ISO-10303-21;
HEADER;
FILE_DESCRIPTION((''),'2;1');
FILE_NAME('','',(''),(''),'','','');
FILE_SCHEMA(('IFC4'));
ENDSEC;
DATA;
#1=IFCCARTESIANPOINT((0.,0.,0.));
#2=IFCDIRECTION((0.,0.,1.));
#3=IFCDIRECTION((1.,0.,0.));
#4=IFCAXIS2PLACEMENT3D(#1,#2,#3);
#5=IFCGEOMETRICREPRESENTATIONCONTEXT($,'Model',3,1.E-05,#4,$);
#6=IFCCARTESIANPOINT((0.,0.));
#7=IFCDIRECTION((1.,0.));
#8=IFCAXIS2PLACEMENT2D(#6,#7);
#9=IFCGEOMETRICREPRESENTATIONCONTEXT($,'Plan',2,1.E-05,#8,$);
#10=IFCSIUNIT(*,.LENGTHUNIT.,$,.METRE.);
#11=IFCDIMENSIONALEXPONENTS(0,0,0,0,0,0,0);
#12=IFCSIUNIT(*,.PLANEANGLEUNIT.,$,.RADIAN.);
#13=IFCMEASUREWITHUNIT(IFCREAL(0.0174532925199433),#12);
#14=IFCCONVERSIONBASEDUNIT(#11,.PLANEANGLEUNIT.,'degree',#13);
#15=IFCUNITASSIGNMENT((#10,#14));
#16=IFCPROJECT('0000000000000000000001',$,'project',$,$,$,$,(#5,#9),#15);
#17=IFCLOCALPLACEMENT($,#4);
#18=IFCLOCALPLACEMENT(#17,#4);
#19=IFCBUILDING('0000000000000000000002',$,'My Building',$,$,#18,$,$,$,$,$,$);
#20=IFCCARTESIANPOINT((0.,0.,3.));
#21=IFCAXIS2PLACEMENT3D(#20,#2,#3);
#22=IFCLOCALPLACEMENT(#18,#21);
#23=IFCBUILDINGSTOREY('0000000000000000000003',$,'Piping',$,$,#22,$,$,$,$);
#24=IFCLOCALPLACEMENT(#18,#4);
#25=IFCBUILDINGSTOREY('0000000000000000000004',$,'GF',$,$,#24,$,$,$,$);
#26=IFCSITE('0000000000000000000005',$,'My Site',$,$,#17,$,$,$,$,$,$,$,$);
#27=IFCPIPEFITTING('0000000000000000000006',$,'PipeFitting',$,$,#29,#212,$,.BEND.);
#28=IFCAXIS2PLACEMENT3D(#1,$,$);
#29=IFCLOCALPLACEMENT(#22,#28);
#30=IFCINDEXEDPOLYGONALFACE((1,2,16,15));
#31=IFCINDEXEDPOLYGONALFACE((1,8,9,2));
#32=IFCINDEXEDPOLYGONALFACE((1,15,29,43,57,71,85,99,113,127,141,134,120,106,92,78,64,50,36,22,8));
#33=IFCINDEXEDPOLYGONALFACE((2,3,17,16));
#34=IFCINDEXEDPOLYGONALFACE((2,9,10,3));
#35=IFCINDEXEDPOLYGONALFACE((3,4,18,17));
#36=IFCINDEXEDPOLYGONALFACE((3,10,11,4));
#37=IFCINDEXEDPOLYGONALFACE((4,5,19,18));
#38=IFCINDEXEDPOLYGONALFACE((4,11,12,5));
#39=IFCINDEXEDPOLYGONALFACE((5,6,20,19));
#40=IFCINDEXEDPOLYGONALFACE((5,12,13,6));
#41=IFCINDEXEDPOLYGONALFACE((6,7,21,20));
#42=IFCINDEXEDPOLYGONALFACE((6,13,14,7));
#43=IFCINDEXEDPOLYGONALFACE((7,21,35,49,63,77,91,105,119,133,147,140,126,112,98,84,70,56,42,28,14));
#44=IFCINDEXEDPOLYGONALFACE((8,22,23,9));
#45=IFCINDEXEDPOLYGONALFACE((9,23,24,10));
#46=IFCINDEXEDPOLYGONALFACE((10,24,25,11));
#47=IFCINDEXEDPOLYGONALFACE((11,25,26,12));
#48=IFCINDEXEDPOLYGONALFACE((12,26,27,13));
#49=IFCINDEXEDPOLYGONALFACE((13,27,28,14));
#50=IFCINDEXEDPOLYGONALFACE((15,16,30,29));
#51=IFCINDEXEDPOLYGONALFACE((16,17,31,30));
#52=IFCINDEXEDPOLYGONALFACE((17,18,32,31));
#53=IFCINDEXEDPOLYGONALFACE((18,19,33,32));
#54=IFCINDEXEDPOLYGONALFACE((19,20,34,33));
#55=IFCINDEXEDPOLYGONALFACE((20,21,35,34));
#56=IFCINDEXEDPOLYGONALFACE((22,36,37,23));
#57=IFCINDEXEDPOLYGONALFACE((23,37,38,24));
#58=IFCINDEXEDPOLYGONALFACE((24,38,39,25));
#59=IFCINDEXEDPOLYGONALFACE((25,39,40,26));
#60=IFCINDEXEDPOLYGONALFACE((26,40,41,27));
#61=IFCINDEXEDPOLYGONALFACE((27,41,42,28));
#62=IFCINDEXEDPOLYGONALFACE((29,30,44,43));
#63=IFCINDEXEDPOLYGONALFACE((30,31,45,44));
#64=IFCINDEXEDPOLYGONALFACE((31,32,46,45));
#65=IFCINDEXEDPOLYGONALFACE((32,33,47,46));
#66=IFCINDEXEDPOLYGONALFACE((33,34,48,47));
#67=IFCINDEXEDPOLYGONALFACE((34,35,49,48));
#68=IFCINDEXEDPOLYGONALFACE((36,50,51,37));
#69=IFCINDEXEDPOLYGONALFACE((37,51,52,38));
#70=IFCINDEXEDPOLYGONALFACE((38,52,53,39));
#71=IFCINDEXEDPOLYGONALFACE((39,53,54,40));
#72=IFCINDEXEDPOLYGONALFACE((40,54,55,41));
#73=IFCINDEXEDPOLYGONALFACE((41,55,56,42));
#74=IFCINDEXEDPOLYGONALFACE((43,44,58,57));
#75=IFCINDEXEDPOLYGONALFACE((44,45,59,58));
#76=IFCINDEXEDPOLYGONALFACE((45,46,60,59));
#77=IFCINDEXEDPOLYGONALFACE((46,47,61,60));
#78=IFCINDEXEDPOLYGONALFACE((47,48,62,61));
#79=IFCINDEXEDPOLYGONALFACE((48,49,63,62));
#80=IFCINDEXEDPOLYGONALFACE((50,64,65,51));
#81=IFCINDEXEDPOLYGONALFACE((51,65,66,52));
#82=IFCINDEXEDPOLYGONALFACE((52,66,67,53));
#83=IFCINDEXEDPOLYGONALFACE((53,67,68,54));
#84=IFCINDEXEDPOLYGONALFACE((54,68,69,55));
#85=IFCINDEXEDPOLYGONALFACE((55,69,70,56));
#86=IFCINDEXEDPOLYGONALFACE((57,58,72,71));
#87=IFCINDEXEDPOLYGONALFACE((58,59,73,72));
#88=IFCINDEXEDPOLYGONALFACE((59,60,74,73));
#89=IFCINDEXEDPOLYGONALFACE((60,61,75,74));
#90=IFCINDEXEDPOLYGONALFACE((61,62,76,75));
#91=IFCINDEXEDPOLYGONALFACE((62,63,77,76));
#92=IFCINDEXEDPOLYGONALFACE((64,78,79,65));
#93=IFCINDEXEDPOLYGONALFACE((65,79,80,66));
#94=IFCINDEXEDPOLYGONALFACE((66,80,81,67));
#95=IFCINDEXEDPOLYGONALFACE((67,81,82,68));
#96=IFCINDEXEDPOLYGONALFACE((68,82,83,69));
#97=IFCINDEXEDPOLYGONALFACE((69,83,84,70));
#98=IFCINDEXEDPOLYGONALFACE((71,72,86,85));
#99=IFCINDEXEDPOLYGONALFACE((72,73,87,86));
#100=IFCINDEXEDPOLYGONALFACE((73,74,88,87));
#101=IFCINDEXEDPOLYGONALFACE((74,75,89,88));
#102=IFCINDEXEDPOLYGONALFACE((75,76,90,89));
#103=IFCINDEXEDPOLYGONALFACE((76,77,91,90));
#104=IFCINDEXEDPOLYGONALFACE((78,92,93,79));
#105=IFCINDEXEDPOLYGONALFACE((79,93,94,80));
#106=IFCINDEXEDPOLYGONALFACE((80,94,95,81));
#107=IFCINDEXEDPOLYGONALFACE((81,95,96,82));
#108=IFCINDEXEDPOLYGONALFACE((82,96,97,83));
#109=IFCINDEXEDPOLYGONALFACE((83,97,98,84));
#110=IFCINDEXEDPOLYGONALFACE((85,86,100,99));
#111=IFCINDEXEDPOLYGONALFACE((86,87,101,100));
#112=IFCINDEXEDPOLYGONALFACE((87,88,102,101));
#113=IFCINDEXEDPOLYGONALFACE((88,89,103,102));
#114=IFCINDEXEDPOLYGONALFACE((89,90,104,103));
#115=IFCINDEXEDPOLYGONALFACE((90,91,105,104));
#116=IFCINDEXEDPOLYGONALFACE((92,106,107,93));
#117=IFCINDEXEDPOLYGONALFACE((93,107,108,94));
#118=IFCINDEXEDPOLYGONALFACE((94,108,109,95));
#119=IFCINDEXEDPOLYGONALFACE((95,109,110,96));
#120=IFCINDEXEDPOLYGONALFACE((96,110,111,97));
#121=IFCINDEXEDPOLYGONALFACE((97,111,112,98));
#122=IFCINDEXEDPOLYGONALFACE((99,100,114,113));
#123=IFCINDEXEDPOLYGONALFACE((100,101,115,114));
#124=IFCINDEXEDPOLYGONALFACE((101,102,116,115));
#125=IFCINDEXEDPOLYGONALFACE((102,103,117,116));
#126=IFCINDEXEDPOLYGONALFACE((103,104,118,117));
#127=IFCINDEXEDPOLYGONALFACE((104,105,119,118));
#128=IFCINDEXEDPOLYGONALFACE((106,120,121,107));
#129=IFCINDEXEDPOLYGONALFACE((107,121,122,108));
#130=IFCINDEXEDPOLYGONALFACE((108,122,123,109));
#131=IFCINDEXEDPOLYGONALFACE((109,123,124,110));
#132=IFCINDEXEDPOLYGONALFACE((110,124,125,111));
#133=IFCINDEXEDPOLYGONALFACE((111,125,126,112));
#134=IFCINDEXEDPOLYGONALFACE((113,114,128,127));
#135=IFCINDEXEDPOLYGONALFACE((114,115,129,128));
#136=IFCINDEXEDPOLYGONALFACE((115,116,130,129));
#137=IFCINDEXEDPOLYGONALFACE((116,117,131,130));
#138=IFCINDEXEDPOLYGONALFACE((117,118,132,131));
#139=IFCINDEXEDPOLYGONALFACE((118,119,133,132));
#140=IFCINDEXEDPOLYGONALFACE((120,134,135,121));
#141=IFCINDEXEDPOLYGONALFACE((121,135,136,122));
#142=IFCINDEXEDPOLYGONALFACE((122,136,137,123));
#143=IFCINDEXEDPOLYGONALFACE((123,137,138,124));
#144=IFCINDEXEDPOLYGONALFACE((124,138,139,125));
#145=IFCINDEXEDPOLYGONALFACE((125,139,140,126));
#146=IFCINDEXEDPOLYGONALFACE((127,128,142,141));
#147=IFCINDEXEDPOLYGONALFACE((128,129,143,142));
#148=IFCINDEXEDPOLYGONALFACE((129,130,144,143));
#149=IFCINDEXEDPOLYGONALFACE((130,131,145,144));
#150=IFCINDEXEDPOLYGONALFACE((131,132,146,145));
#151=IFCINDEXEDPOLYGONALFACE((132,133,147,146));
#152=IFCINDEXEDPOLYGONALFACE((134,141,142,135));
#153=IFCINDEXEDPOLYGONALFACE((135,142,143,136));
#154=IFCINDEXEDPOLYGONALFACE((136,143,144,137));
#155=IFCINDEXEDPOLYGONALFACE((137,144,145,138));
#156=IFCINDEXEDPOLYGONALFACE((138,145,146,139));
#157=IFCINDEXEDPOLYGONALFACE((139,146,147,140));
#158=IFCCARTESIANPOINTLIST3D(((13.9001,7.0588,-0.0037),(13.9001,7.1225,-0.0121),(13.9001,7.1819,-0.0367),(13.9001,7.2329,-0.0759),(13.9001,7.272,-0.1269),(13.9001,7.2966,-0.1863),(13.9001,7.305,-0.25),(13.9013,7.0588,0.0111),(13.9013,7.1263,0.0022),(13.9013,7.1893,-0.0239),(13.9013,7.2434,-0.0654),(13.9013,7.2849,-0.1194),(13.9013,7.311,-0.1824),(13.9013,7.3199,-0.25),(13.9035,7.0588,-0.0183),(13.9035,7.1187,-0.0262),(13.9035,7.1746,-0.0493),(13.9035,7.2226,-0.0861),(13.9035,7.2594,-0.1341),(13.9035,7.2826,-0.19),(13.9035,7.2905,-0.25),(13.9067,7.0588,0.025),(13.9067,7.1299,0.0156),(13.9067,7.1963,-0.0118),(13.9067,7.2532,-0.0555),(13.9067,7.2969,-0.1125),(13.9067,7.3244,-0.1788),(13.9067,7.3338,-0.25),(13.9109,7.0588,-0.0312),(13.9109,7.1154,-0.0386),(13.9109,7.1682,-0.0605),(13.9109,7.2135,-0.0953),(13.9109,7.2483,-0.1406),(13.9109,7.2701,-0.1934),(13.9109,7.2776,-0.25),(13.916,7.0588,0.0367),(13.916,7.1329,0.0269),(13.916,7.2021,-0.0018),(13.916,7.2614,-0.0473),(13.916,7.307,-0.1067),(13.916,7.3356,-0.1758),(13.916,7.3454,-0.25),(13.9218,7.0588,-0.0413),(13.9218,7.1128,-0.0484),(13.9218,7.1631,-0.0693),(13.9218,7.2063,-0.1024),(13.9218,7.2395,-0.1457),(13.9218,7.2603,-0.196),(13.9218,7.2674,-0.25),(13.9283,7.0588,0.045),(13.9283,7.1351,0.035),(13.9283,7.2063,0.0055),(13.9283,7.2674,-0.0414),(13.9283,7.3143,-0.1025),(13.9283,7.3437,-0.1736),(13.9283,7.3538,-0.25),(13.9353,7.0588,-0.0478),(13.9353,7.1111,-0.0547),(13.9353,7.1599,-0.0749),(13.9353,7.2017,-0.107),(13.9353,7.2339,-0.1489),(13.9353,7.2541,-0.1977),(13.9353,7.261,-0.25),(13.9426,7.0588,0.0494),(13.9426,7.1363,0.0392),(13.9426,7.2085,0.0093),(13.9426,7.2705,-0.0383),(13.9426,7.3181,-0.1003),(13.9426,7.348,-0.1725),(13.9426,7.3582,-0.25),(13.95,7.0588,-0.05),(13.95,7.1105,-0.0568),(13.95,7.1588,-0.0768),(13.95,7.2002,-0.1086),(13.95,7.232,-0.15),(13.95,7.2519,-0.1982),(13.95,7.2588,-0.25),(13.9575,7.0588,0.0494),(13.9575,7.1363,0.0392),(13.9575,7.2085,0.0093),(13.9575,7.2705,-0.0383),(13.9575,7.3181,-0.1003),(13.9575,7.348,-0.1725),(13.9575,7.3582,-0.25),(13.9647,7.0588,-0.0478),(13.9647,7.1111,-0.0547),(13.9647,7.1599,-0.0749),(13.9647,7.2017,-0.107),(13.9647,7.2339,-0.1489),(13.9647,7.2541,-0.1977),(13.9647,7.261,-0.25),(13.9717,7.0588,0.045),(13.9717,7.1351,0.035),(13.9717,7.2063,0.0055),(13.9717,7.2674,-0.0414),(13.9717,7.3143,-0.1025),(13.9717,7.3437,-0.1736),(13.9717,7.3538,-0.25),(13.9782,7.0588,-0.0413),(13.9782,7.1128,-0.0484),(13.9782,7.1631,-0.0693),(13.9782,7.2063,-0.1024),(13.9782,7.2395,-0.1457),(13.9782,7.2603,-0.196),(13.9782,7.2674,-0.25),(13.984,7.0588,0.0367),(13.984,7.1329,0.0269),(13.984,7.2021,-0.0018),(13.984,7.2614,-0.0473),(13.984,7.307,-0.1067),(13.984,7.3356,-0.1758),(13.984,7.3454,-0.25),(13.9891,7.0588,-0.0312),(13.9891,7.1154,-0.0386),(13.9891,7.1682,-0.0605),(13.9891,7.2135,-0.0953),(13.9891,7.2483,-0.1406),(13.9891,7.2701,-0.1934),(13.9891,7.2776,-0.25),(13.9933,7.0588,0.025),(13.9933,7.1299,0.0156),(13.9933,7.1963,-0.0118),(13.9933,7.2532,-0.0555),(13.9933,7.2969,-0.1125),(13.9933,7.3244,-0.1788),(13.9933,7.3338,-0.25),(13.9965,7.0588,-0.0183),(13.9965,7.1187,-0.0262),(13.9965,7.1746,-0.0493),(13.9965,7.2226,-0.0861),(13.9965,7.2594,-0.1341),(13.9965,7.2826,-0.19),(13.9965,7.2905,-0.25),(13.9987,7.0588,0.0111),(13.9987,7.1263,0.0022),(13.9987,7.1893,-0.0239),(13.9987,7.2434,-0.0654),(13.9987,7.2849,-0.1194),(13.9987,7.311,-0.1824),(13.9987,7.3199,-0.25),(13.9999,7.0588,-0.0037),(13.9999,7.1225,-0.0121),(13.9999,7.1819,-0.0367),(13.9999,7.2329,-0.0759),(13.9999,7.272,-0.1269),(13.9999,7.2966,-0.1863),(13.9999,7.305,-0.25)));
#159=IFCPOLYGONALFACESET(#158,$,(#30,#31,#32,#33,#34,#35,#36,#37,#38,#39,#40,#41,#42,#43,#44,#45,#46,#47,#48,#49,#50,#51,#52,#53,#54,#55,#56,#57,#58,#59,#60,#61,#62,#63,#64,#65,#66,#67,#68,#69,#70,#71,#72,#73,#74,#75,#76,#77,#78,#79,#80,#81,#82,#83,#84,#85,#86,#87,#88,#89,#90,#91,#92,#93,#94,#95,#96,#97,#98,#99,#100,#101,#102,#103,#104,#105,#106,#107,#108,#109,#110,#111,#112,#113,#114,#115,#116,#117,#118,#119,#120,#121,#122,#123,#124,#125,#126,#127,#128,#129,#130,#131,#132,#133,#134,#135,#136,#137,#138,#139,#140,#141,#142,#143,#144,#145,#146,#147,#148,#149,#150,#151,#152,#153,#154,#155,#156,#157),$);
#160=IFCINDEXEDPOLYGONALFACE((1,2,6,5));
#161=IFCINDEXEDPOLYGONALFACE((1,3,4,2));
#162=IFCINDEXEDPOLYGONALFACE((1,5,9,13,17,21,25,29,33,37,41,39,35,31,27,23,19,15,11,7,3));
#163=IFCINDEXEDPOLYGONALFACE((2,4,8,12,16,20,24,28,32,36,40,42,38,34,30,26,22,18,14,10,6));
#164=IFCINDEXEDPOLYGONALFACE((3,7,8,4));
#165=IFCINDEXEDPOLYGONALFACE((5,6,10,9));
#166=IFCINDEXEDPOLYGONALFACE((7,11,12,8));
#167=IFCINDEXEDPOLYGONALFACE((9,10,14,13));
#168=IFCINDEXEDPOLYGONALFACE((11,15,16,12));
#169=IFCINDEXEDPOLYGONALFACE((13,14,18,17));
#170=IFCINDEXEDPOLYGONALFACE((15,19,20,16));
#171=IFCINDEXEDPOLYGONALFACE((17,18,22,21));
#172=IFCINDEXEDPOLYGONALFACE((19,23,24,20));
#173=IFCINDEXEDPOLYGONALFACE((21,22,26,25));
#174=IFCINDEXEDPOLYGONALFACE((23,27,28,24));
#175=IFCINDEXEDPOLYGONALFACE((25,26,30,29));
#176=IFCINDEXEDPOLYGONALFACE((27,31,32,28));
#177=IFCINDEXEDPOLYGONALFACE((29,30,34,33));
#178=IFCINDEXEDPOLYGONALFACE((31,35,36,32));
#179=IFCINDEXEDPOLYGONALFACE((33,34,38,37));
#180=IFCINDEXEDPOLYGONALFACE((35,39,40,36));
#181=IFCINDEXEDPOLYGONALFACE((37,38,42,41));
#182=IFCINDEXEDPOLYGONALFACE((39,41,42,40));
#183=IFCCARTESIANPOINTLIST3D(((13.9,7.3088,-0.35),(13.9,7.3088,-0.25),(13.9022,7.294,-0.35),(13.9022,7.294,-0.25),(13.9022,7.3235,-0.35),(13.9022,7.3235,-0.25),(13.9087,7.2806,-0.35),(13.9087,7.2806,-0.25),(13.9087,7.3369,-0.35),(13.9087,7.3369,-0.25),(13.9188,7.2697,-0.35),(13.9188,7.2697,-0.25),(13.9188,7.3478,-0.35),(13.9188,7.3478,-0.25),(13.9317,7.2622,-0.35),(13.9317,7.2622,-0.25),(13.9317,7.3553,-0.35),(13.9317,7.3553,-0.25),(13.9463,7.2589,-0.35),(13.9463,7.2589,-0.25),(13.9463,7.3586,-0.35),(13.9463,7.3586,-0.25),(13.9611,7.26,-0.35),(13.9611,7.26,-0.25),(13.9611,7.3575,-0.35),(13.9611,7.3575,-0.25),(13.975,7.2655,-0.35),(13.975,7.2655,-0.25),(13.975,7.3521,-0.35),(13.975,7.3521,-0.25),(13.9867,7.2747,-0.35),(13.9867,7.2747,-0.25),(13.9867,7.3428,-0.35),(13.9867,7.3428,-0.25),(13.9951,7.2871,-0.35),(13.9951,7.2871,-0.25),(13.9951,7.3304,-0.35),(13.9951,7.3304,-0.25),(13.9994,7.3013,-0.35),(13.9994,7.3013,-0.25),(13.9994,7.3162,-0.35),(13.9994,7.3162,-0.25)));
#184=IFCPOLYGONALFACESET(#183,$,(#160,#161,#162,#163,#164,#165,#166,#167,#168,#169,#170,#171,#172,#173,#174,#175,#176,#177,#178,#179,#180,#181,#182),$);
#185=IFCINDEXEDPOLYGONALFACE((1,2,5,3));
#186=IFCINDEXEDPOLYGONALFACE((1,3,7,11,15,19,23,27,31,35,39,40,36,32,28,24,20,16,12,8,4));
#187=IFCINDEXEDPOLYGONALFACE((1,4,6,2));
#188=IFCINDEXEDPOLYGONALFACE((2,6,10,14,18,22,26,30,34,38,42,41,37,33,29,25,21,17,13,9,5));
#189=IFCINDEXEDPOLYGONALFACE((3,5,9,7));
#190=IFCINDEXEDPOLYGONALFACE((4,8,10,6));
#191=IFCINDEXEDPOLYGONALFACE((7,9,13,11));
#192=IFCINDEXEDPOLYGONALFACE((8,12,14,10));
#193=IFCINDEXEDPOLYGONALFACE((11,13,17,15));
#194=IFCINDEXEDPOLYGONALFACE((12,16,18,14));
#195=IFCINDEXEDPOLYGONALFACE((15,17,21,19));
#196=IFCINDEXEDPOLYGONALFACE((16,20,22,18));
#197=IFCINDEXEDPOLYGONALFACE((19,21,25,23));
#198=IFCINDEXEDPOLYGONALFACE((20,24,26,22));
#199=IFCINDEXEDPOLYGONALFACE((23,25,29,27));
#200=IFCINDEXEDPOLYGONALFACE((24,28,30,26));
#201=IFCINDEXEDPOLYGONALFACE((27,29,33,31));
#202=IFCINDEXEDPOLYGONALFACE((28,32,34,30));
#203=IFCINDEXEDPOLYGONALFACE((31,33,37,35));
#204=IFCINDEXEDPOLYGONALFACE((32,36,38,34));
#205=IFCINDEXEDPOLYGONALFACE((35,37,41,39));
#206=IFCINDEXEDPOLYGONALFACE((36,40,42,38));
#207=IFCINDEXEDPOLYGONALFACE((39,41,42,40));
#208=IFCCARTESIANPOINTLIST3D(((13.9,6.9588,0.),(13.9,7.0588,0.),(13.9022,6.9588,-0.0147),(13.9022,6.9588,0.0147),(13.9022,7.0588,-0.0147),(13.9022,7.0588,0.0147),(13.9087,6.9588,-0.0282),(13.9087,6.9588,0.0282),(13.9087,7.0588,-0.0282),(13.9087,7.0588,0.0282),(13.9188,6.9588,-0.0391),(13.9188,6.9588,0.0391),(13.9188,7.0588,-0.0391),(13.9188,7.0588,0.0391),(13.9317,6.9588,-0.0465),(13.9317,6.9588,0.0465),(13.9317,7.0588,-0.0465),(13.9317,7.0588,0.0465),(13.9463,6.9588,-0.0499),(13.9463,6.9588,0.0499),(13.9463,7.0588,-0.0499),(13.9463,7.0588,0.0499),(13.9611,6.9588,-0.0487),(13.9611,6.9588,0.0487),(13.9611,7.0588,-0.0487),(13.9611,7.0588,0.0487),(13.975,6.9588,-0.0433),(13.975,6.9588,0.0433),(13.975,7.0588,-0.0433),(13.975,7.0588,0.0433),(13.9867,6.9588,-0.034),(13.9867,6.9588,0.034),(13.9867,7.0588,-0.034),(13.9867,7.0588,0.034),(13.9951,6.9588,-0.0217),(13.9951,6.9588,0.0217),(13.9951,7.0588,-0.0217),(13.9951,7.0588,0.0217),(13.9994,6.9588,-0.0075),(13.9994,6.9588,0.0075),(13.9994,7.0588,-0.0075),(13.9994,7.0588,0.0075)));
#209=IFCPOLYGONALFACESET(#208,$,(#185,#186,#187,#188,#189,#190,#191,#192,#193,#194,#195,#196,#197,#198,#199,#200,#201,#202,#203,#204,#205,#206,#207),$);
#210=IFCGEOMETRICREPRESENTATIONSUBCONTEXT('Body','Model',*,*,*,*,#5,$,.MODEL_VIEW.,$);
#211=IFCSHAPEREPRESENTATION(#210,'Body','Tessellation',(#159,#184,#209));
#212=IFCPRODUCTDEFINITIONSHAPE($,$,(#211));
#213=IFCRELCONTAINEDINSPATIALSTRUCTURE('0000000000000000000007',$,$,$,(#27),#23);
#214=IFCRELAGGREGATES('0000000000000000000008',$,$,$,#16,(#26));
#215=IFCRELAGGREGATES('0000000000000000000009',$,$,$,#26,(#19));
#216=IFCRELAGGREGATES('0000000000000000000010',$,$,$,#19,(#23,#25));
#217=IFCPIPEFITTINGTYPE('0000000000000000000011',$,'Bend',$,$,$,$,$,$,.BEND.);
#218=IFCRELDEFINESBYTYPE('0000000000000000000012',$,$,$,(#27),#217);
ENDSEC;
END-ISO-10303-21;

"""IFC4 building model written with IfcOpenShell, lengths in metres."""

from ifc_helpers import new_model, entity, si_unit, converted_unit, frame, origin_with_axes, origin_2d_with_axis, place, context, subcontext, project, spatial, circle, extrude, source, transform, mapped, type_object, type_shapes, element, save


model = new_model("IFC4")

# Units and contexts
model_context = context("Model", 3, precision=1e-05, world=origin_with_axes())
plan_context = context("Plan", 2, precision=1e-05, world=origin_2d_with_axis())
body_context_1 = subcontext(model_context, "Body", "Model", "MODEL_VIEW")
ifc_project = project(units=[si_unit("LENGTHUNIT", "METRE"), converted_unit("PLANEANGLEUNIT", "degree", entity("IfcReal", 0.0174532925199433), si_unit("PLANEANGLEUNIT", "RADIAN"), dimensions=[0, 0, 0, 0, 0, 0, 0])], contexts=[model_context, plan_context])

# Site, building, storey
site_placement = place(None, origin_with_axes())
site = spatial("IfcSite", under=ifc_project, at=site_placement, Name="My Site")
building_placement = place(site_placement, origin_with_axes())
building = spatial("IfcBuilding", under=site, at=building_placement, Name="My Building")
storey_1_placement = place(building_placement, frame((0.0, 0.0, 3.0), z_axis=(0.0, 0.0, 1.0), x_axis=(1.0, 0.0, 0.0)))
storey_1 = spatial("IfcBuildingStorey", under=building, at=storey_1_placement, Name="Piping")

# Shared definitions
storey_2_placement = place(building_placement, origin_with_axes())
storey_2 = spatial("IfcBuildingStorey", under=building, at=storey_2_placement, Name="GF")

# Pipe fitting
pipe_fitting_type_1 = type_object("IfcPipeFittingType", Name="Bend", PredefinedType="BEND")
shared_shape_1 = source(origin_with_axes(), body_context_1, "Body", "SolidModel", [
    entity("IfcSweptDiskSolid", entity("IfcIndexedPolyCurve", entity("IfcCartesianPointList3D", [[0.0, 0.0, -0.1], [0.0, -0.0732, -0.2768], [0.0, -0.25, -0.35]]), [entity("IfcArcIndex", [1, 2, 3])]), 0.05),
    extrude(circle(Radius=0.05), origin_with_axes(), (0.0, 0.0, -1.0), 0.1),
    extrude(circle(Radius=0.05), frame((0.0, -0.25, -0.35), z_axis=(0.0, -1.0, 0.0), x_axis=(1.0, 0.0, 0.0)), (0.0, 0.0, 1.0), 0.1),
])
type_shapes(pipe_fitting_type_1, [shared_shape_1])
for number, where, z_axis, x_axis, name in (
    (1, (13.95, 7.3088, -0.35), (0.0, 0.0, -1.0), (-1.0, 0.0, 0.0), "PipeFitting"),
):
    element("IfcPipeFitting", number, at=place(storey_1_placement, frame(where, z_axis=z_axis, x_axis=x_axis)), inside=storey_1, type_object=pipe_fitting_type_1, Name=name, PredefinedType="BEND", context=body_context_1, shape_type="MappedRepresentation", body=[
        mapped(shared_shape_1, transform((0.0, 0.0, 0.0), x_axis=(1.0, 0.0, 0.0), y_axis=(0.0, 1.0, 0.0), z_axis=(0.0, 0.0, 1.0), scale=1.0)),
    ])

save(model, "model.ifc")
